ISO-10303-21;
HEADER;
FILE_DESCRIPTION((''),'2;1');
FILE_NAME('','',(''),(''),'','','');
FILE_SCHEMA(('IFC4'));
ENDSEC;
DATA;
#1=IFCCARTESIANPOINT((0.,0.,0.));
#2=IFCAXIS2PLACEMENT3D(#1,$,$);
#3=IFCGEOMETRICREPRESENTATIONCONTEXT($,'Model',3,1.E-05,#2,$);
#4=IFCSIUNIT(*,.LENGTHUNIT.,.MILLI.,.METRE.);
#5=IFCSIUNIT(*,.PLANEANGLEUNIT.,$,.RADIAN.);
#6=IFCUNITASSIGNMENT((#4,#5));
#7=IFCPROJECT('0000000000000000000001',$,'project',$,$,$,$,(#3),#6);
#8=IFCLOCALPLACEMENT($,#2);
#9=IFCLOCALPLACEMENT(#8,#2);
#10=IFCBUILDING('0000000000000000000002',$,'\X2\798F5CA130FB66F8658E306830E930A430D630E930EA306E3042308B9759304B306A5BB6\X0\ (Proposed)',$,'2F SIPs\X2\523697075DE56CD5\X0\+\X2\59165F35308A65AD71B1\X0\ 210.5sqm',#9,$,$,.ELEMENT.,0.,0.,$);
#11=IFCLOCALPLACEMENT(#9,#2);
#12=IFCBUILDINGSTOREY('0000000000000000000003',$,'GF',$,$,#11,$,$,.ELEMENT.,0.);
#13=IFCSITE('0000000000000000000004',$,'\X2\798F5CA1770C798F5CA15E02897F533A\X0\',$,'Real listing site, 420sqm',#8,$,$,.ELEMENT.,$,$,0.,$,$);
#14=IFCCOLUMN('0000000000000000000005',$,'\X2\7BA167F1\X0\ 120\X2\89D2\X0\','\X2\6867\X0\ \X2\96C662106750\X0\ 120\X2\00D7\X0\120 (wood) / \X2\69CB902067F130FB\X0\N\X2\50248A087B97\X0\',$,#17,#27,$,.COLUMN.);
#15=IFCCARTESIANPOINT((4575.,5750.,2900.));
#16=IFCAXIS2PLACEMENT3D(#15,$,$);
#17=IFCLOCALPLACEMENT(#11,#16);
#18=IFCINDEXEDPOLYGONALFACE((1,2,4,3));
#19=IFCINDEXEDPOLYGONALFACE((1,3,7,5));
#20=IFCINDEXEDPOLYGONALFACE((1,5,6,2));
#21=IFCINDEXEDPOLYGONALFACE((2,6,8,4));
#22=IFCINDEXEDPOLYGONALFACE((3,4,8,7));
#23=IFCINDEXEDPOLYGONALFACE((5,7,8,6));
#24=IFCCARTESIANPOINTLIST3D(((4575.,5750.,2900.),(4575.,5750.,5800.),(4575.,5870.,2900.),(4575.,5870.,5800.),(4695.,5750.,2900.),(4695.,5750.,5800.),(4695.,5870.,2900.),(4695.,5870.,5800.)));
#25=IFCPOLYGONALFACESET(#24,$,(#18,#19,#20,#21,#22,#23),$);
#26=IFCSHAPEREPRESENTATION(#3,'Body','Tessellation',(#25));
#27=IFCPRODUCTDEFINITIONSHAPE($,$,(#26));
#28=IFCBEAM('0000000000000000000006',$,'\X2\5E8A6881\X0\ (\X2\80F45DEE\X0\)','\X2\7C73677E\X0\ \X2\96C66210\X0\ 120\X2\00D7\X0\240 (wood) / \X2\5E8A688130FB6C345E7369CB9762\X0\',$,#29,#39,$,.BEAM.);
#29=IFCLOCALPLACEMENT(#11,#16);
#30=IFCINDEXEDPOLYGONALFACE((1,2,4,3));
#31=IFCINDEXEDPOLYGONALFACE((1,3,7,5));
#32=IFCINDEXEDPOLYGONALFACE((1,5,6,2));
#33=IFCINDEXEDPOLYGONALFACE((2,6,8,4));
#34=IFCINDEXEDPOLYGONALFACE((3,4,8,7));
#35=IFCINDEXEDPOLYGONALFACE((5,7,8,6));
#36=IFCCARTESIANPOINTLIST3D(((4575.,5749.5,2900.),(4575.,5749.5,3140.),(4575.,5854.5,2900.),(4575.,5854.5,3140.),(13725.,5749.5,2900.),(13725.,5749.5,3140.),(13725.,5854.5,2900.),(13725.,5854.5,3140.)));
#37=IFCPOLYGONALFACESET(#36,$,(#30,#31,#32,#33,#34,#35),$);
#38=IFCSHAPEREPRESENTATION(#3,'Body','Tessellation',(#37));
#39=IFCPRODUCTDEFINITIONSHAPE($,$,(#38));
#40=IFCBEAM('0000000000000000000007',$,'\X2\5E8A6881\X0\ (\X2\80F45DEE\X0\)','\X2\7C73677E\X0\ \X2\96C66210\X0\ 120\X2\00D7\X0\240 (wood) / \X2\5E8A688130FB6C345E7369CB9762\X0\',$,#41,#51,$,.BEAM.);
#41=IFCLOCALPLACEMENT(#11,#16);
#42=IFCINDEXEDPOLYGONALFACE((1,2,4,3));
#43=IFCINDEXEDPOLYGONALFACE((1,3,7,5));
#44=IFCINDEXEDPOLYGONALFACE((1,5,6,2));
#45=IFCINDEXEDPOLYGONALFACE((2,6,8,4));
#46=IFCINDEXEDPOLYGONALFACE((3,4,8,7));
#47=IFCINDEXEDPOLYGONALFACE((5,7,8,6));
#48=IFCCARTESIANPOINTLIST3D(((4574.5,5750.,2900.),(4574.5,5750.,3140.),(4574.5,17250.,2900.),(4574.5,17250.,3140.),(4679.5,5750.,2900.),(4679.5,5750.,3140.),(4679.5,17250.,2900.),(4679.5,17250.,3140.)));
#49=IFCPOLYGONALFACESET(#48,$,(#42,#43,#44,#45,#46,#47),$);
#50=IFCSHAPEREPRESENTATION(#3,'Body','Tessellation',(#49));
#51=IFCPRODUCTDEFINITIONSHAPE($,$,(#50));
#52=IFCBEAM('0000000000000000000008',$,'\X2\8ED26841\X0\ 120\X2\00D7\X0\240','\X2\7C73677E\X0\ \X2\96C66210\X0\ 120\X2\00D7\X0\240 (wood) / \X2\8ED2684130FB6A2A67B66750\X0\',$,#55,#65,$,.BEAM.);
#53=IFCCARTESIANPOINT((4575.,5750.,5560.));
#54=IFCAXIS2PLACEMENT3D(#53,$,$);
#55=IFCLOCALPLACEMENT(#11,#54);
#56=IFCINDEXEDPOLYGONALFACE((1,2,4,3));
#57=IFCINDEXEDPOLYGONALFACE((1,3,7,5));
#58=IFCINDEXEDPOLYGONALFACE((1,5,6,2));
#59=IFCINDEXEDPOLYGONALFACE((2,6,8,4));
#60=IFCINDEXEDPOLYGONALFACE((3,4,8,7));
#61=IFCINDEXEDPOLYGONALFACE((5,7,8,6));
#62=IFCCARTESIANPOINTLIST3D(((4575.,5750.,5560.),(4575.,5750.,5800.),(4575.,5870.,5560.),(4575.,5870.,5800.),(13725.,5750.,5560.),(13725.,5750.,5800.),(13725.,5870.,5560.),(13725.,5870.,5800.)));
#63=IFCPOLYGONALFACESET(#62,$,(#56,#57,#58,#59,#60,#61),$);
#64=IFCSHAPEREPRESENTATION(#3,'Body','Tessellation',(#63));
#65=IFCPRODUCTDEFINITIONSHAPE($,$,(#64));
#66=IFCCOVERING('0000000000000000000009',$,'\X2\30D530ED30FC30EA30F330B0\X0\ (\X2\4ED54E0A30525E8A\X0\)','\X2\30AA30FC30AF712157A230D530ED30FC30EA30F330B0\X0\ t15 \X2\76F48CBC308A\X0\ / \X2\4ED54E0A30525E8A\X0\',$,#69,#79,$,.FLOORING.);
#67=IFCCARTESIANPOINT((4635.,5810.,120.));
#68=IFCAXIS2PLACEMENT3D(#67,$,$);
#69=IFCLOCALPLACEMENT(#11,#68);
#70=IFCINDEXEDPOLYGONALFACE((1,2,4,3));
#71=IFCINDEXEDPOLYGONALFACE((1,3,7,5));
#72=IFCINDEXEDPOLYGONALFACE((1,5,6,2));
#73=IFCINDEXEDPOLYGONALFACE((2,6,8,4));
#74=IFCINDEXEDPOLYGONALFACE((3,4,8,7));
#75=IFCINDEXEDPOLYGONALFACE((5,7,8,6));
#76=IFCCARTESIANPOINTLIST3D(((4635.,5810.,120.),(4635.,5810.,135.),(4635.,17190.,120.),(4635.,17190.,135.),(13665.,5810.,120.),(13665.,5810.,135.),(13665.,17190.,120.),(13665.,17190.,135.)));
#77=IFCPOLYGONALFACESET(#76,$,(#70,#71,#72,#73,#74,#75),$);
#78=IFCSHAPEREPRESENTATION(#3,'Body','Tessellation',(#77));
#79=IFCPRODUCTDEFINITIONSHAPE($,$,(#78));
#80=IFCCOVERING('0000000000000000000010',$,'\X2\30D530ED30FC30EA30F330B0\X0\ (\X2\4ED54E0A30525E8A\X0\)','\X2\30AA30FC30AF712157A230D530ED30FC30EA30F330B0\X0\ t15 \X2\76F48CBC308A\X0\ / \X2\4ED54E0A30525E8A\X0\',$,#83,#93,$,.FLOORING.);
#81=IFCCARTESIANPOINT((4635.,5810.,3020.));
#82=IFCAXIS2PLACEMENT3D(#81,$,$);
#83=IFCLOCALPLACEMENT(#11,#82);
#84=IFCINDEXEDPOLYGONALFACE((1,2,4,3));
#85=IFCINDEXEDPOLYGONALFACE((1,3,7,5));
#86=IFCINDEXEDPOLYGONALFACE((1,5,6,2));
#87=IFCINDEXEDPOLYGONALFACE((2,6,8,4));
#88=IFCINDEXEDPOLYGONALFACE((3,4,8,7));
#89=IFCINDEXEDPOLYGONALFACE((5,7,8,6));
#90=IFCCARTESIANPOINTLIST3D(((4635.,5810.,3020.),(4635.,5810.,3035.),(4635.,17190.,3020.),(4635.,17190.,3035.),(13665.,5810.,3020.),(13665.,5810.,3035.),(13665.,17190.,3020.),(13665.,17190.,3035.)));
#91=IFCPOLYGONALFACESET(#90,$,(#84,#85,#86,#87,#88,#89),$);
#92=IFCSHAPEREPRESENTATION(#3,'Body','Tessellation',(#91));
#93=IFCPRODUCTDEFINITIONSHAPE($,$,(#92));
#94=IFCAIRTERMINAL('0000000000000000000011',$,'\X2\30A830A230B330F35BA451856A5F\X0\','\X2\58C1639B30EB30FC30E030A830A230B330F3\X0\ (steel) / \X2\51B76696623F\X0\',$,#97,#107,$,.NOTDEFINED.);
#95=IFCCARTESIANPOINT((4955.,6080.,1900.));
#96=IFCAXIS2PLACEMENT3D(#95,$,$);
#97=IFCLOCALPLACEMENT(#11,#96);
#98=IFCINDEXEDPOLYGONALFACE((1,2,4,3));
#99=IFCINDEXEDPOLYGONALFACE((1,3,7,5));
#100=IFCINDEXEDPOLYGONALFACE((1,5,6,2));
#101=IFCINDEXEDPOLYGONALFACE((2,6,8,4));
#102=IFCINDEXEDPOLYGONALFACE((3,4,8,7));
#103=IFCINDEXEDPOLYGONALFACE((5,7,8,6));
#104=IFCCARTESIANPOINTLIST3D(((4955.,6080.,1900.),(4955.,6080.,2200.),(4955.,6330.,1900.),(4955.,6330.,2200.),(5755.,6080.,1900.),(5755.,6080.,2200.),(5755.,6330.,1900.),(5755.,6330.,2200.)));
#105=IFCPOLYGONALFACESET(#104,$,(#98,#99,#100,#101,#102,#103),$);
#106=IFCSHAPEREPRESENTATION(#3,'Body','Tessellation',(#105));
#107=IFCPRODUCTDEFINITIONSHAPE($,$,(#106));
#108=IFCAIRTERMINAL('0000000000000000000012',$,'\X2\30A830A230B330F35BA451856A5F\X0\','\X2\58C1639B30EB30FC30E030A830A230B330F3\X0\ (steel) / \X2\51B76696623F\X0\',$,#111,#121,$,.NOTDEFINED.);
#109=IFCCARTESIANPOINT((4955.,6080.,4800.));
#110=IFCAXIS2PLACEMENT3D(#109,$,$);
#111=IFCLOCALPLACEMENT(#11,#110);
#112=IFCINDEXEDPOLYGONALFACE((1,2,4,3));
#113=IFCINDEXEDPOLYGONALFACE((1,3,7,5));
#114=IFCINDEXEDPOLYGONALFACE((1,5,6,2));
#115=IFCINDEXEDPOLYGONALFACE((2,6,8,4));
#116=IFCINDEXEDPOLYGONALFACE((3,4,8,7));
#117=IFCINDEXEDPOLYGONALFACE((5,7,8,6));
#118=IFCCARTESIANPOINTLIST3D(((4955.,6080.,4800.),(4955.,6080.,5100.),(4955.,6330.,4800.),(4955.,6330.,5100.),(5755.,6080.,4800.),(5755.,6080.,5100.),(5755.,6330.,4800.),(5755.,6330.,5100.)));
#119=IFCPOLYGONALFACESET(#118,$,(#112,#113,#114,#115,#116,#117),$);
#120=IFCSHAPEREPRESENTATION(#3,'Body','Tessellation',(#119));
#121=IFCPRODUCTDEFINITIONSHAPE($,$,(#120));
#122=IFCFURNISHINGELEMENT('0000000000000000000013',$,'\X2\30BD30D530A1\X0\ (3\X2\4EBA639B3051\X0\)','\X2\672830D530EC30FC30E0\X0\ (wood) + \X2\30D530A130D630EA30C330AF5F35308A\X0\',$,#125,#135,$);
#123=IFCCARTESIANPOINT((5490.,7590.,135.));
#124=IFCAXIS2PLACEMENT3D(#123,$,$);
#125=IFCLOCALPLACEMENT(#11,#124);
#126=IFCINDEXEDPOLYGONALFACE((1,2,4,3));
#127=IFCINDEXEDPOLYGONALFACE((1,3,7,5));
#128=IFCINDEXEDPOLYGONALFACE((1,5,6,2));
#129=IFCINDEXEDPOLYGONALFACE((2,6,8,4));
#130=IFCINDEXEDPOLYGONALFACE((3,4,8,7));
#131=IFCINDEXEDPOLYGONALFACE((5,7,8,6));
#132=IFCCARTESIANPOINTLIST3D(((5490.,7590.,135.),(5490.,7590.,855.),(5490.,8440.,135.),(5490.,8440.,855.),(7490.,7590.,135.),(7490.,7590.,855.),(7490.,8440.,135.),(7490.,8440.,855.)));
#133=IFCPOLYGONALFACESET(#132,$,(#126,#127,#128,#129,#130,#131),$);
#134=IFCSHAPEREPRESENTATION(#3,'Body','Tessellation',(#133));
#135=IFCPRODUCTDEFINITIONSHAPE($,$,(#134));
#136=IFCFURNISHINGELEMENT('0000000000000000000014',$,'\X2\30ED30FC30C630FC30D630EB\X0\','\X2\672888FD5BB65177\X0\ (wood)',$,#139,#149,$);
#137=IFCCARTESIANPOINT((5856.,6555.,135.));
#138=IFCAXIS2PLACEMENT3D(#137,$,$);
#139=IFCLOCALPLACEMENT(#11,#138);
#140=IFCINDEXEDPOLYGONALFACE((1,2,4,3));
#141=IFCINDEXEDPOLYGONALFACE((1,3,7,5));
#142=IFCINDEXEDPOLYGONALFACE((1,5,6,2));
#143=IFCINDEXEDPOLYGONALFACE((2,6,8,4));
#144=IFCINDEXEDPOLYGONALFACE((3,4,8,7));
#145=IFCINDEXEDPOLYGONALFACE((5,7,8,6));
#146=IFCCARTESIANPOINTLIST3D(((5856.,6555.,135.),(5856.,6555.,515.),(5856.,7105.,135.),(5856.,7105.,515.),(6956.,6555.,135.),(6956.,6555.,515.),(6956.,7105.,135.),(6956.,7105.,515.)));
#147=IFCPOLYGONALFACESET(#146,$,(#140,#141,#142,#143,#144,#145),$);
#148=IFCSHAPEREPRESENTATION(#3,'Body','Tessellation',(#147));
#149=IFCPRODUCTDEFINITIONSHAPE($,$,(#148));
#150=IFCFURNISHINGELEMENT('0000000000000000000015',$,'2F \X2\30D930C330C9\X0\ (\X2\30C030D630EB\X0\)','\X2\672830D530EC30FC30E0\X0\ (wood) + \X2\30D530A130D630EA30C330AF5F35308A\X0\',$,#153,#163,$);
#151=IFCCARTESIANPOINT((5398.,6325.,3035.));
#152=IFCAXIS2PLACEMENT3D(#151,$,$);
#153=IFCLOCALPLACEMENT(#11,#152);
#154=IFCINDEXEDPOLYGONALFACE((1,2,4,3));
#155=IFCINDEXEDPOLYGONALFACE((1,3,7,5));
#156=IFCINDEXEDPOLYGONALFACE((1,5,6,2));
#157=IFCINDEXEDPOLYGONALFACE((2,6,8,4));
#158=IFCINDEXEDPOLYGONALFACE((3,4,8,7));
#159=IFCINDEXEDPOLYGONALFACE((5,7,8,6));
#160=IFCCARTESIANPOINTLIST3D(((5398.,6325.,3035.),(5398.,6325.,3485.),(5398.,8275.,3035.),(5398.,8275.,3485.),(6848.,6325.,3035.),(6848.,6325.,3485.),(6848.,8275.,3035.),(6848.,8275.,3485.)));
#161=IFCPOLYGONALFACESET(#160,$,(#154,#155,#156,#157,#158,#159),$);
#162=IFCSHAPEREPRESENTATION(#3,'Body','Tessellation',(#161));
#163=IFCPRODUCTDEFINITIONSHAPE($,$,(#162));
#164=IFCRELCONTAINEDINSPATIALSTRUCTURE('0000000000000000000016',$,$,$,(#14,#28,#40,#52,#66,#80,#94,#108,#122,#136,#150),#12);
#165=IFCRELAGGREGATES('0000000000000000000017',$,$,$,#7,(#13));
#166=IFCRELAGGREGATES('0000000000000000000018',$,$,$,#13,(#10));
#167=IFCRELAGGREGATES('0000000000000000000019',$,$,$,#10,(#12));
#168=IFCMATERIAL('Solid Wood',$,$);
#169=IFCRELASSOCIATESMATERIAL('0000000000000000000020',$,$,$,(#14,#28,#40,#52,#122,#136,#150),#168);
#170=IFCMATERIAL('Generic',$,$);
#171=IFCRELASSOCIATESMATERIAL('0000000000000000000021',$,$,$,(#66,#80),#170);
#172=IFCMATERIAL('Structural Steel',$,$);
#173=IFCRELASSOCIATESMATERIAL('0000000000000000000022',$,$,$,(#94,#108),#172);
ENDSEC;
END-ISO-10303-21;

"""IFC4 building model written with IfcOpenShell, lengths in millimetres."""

from ifc_helpers import new_model, si_unit, frame, frame_2d, origin, place, context, project, spatial, rectangle, extrude, material, element, save


model = new_model("IFC4")

# Units and contexts
model_context = context("Model", 3, precision=1e-05, world=origin())
ifc_project = project(units=[si_unit("LENGTHUNIT", "METRE", prefix="MILLI"), si_unit("PLANEANGLEUNIT", "RADIAN")], contexts=[model_context])

# Site, building, storey
site_placement = place(None, origin())
site = spatial("IfcSite", under=ifc_project, at=site_placement, Name="福岡県福岡市西区", ObjectType="Real listing site, 420sqm", CompositionType="ELEMENT", RefElevation=0.0)
building_placement = place(site_placement, origin())
building = spatial("IfcBuilding", under=site, at=building_placement, Name="福岡・書斎とライブラリのある静かな家 (Proposed)", ObjectType="2F SIPs制震工法+外張り断熱 210.5sqm", CompositionType="ELEMENT", ElevationOfRefHeight=0.0, ElevationOfTerrain=0.0)
storey_placement = place(building_placement, origin())
storey = spatial("IfcBuildingStorey", under=building, at=storey_placement, Name="GF", CompositionType="ELEMENT", Elevation=0.0)

# Column
ifc_material_1 = material(Name="Solid Wood")
column_1_placement = place(storey_placement, frame((4575.0, 5750.0, 2900.0)))
element("IfcColumn", 1, at=column_1_placement, inside=storey, material=ifc_material_1, Name="管柱 120角", Description="桧 集成材 120×120 (wood) / 構造柱・N値計算", PredefinedType="COLUMN", context=model_context, shape_type="SweptSolid", body=[
    extrude(rectangle(XDim=120.0, YDim=120.0, at=frame_2d((60.0, 60.0))), frame((4575.0, 5750.0, 2900.0)), (0.0, 0.0, 1.0), 2900.0),
])

# Beams
beam_1_placement = place(storey_placement, frame((4575.0, 5750.0, 2900.0)))
element("IfcBeam", 2, at=beam_1_placement, inside=storey, material=ifc_material_1, Name="床梁 (胴差)", Description="米松 集成 120×240 (wood) / 床梁・水平構面", PredefinedType="BEAM", context=model_context, shape_type="SweptSolid", body=[
    extrude(rectangle(XDim=9150.0, YDim=105.0, at=frame_2d((4575.0, 52.0))), frame((4575.0, 5750.0, 2900.0)), (0.0, 0.0, 1.0), 240.0),
])
beam_2_placement = place(storey_placement, frame((4575.0, 5750.0, 2900.0)))
element("IfcBeam", 3, at=beam_2_placement, inside=storey, material=ifc_material_1, Name="床梁 (胴差)", Description="米松 集成 120×240 (wood) / 床梁・水平構面", PredefinedType="BEAM", context=model_context, shape_type="SweptSolid", body=[
    extrude(rectangle(XDim=105.0, YDim=11500.0, at=frame_2d((52.0, 5750.0))), frame((4575.0, 5750.0, 2900.0)), (0.0, 0.0, 1.0), 240.0),
])
beam_3_placement = place(storey_placement, frame((4575.0, 5750.0, 5560.0)))
element("IfcBeam", 4, at=beam_3_placement, inside=storey, material=ifc_material_1, Name="軒桁 120×240", Description="米松 集成 120×240 (wood) / 軒桁・横架材", PredefinedType="BEAM", context=model_context, shape_type="SweptSolid", body=[
    extrude(rectangle(XDim=9150.0, YDim=120.0, at=frame_2d((4575.0, 60.0))), frame((4575.0, 5750.0, 5560.0)), (0.0, 0.0, 1.0), 240.0),
])

# Coverings
ifc_material_2 = material(Name="Generic")
covering_1_placement = place(storey_placement, frame((4635.0, 5810.0, 120.0)))
element("IfcCovering", 5, at=covering_1_placement, inside=storey, material=ifc_material_2, Name="フローリング (仕上げ床)", Description="オーク無垢フローリング t15 直貼り / 仕上げ床", PredefinedType="FLOORING", context=model_context, shape_type="SweptSolid", body=[
    extrude(rectangle(XDim=9030.0, YDim=11380.0, at=frame_2d((4515.0, 5690.0))), frame((4635.0, 5810.0, 120.0)), (0.0, 0.0, 1.0), 15.0),
])
covering_2_placement = place(storey_placement, frame((4635.0, 5810.0, 3020.0)))
element("IfcCovering", 6, at=covering_2_placement, inside=storey, material=ifc_material_2, Name="フローリング (仕上げ床)", Description="オーク無垢フローリング t15 直貼り / 仕上げ床", PredefinedType="FLOORING", context=model_context, shape_type="SweptSolid", body=[
    extrude(rectangle(XDim=9030.0, YDim=11380.0, at=frame_2d((4515.0, 5690.0))), frame((4635.0, 5810.0, 3020.0)), (0.0, 0.0, 1.0), 15.0),
])

# Air terminals
ifc_material_3 = material(Name="Structural Steel")
air_terminal_1_placement = place(storey_placement, frame((4955.0, 6080.0, 1900.0)))
element("IfcAirTerminal", 7, at=air_terminal_1_placement, inside=storey, material=ifc_material_3, Name="エアコン室内機", Description="壁掛ルームエアコン (steel) / 冷暖房", PredefinedType="NOTDEFINED", context=model_context, shape_type="SweptSolid", body=[
    extrude(rectangle(XDim=800.0, YDim=250.0, at=frame_2d((400.0, 125.0))), frame((4955.0, 6080.0, 1900.0)), (0.0, 0.0, 1.0), 300.0),
])
air_terminal_2_placement = place(storey_placement, frame((4955.0, 6080.0, 4800.0)))
element("IfcAirTerminal", 8, at=air_terminal_2_placement, inside=storey, material=ifc_material_3, Name="エアコン室内機", Description="壁掛ルームエアコン (steel) / 冷暖房", PredefinedType="NOTDEFINED", context=model_context, shape_type="SweptSolid", body=[
    extrude(rectangle(XDim=800.0, YDim=250.0, at=frame_2d((400.0, 125.0))), frame((4955.0, 6080.0, 4800.0)), (0.0, 0.0, 1.0), 300.0),
])

# Furnishing elements
furnishing_1_placement = place(storey_placement, frame((5490.0, 7590.0, 135.0)))
element("IfcFurnishingElement", 9, at=furnishing_1_placement, inside=storey, material=ifc_material_1, Name="ソファ (3人掛け)", Description="木フレーム (wood) + ファブリック張り", context=model_context, shape_type="SweptSolid", body=[
    extrude(rectangle(XDim=2000.0, YDim=850.0, at=frame_2d((1000.0, 425.0))), frame((5490.0, 7590.0, 135.0)), (0.0, 0.0, 1.0), 720.0),
])
furnishing_2_placement = place(storey_placement, frame((5856.0, 6555.0, 135.0)))
element("IfcFurnishingElement", 10, at=furnishing_2_placement, inside=storey, material=ifc_material_1, Name="ローテーブル", Description="木製家具 (wood)", context=model_context, shape_type="SweptSolid", body=[
    extrude(rectangle(XDim=1100.0, YDim=550.0, at=frame_2d((550.0, 275.0))), frame((5856.0, 6555.0, 135.0)), (0.0, 0.0, 1.0), 380.0),
])
furnishing_3_placement = place(storey_placement, frame((5398.0, 6325.0, 3035.0)))
element("IfcFurnishingElement", 11, at=furnishing_3_placement, inside=storey, material=ifc_material_1, Name="2F ベッド (ダブル)", Description="木フレーム (wood) + ファブリック張り", context=model_context, shape_type="SweptSolid", body=[
    extrude(rectangle(XDim=1450.0, YDim=1950.0, at=frame_2d((725.0, 975.0))), frame((5398.0, 6325.0, 3035.0)), (0.0, 0.0, 1.0), 450.0),
])

save(model, "model.ifc")
